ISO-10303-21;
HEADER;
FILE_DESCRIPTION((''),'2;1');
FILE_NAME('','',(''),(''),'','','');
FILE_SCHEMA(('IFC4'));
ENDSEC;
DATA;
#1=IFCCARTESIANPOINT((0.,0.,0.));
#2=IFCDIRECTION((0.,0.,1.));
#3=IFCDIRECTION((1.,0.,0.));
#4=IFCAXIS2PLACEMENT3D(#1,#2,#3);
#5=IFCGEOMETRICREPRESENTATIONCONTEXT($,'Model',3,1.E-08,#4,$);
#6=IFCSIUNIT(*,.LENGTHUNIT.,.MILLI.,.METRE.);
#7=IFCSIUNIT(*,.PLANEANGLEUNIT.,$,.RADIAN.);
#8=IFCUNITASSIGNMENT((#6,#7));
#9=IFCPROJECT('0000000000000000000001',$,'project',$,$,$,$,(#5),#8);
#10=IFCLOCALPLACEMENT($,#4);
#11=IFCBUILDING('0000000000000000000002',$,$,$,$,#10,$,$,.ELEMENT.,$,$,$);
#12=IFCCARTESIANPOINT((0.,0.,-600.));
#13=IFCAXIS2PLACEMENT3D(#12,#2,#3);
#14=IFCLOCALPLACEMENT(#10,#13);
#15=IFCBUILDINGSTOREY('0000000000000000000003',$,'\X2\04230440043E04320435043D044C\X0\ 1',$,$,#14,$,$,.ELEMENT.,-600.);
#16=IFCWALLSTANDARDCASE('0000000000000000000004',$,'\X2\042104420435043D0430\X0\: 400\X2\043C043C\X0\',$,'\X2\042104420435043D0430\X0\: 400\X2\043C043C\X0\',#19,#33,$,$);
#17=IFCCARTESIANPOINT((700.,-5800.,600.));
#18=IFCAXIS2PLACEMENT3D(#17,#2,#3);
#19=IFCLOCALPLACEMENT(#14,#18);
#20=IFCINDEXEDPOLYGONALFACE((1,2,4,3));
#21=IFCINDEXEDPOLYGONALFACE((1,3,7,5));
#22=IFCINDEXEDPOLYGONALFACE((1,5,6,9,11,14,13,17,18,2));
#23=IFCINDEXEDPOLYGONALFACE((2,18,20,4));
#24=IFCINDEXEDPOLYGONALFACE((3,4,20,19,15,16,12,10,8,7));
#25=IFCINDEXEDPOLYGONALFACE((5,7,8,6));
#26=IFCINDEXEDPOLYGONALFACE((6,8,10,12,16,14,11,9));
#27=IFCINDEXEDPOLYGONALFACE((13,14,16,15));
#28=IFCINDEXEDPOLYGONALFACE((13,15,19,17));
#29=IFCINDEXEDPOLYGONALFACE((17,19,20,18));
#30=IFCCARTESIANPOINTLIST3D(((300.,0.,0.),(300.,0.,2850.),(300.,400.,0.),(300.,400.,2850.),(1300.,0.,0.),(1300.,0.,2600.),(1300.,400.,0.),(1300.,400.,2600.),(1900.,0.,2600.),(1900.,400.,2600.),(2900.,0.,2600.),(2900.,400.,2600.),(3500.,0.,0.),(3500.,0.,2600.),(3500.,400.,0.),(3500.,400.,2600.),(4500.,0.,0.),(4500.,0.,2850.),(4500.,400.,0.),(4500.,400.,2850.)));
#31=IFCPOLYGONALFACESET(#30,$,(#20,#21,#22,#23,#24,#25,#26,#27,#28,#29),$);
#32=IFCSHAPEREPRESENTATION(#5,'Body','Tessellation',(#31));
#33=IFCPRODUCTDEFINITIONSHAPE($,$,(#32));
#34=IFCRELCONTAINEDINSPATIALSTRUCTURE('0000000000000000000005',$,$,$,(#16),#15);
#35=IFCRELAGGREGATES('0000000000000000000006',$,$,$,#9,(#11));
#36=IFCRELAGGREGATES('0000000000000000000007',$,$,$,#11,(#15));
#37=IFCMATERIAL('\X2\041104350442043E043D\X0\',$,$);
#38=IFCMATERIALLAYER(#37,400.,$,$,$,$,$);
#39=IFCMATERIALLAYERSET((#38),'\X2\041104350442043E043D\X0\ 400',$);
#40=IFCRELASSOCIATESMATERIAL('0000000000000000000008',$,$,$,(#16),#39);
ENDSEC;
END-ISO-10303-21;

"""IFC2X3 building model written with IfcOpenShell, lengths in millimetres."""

from ifc_helpers import new_model, si_unit, frame, frame_2d, origin_with_axes, place, context, project, spatial, polyline, segment, composite_curve, rectangle, outline, extrude, material, layer, layer_set, layer_usage, element, save


model = new_model("IFC2X3")

# Units and contexts
model_context = context("Model", 3, precision=1e-08, world=origin_with_axes())
ifc_project = project(units=[si_unit("LENGTHUNIT", "METRE", prefix="MILLI"), si_unit("PLANEANGLEUNIT", "RADIAN")], contexts=[model_context])

# Building, storey
building_placement = place(None, origin_with_axes())
building = spatial("IfcBuilding", under=ifc_project, at=building_placement, CompositionType="ELEMENT")
storey_placement = place(building_placement, frame((0.0, 0.0, -600.0), z_axis=(0.0, 0.0, 1.0), x_axis=(1.0, 0.0, 0.0)))
storey = spatial("IfcBuildingStorey", under=building, at=storey_placement, Name="Уровень 1", CompositionType="ELEMENT", Elevation=-600.0)

# Shared definitions
ifc_material_1 = material(Name="Бетон")

# Shared definitions
ifc_layer_1 = layer(ifc_material_1, 400.0)
ifc_layer_set_1 = layer_set([ifc_layer_1], Name="Бетон 400")

# Wall, openings
ifc_layer_usage_1 = layer_usage(ifc_layer_set_1, "AXIS2", "NEGATIVE", 400.0)
wall_1_placement = place(storey_placement, frame((700.0, -5800.0, 600.0), z_axis=(0.0, 0.0, 1.0), x_axis=(1.0, 0.0, 0.0)))
wall_1 = element("IfcWallStandardCase", 1, at=wall_1_placement, inside=storey, material=ifc_layer_usage_1, Name="Стена: 400мм", ObjectType="Стена: 400мм", context=model_context, shape_type="SweptSolid", body=[
    extrude(outline(composite_curve([segment(polyline([(300.0, 0.0), (4500.0, 0.0)]), True, "CONTINUOUS"), segment(polyline([(4500.0, 0.0), (4500.0, 400.0)]), True, "CONTINUOUS"), segment(polyline([(4500.0, 400.0), (300.0, 400.0)]), True, "CONTINUOUS"), segment(polyline([(300.0, 400.0), (300.0, 0.0)]), True, "CONTINUOUS")], self_intersect=False)), origin_with_axes(), (0.0, 0.0, 1.0), 2850.0),
])
opening_1_placement = place(wall_1_placement, frame((1900.0, 0.0, 0.0), z_axis=(0.0, 0.0, 1.0), x_axis=(1.0, 0.0, 0.0)))
element("IfcOpeningElement", 2, at=opening_1_placement, cuts=wall_1, ObjectType="Opening", context=model_context, shape_type="SweptSolid", body=[
    extrude(rectangle(XDim=1000.0, YDim=2600.0, at=frame_2d((500.0, 1300.0), x_axis=(1.0, 0.0))), frame((0.0, -5.0, 0.0), z_axis=(0.0, -1.0, 0.0), x_axis=(1.0, 0.0, 0.0)), (0.0, 0.0, -1.0), 410.0),
])
opening_2_placement = place(wall_1_placement, frame((1300.0, 0.0, 0.0), z_axis=(0.0, 0.0, 1.0), x_axis=(1.0, 0.0, 0.0)))
element("IfcOpeningElement", 3, at=opening_2_placement, cuts=wall_1, ObjectType="Opening", context=model_context, shape_type="SweptSolid", body=[
    extrude(rectangle(XDim=600.0, YDim=2600.0, at=frame_2d((300.0, 1300.0), x_axis=(1.0, 0.0))), frame((0.0, -5.0, 0.0), z_axis=(0.0, -1.0, 0.0), x_axis=(1.0, 0.0, 0.0)), (0.0, 0.0, -1.0), 410.0),
])
opening_3_placement = place(wall_1_placement, frame((2900.0, 0.0, 0.0), z_axis=(0.0, 0.0, 1.0), x_axis=(1.0, 0.0, 0.0)))
element("IfcOpeningElement", 4, at=opening_3_placement, cuts=wall_1, ObjectType="Opening", context=model_context, shape_type="SweptSolid", body=[
    extrude(rectangle(XDim=600.0, YDim=2600.0, at=frame_2d((300.0, 1300.0), x_axis=(1.0, 0.0))), frame((0.0, -5.0, 0.0), z_axis=(0.0, -1.0, 0.0), x_axis=(1.0, 0.0, 0.0)), (0.0, 0.0, -1.0), 410.0),
])

save(model, "model.ifc")
